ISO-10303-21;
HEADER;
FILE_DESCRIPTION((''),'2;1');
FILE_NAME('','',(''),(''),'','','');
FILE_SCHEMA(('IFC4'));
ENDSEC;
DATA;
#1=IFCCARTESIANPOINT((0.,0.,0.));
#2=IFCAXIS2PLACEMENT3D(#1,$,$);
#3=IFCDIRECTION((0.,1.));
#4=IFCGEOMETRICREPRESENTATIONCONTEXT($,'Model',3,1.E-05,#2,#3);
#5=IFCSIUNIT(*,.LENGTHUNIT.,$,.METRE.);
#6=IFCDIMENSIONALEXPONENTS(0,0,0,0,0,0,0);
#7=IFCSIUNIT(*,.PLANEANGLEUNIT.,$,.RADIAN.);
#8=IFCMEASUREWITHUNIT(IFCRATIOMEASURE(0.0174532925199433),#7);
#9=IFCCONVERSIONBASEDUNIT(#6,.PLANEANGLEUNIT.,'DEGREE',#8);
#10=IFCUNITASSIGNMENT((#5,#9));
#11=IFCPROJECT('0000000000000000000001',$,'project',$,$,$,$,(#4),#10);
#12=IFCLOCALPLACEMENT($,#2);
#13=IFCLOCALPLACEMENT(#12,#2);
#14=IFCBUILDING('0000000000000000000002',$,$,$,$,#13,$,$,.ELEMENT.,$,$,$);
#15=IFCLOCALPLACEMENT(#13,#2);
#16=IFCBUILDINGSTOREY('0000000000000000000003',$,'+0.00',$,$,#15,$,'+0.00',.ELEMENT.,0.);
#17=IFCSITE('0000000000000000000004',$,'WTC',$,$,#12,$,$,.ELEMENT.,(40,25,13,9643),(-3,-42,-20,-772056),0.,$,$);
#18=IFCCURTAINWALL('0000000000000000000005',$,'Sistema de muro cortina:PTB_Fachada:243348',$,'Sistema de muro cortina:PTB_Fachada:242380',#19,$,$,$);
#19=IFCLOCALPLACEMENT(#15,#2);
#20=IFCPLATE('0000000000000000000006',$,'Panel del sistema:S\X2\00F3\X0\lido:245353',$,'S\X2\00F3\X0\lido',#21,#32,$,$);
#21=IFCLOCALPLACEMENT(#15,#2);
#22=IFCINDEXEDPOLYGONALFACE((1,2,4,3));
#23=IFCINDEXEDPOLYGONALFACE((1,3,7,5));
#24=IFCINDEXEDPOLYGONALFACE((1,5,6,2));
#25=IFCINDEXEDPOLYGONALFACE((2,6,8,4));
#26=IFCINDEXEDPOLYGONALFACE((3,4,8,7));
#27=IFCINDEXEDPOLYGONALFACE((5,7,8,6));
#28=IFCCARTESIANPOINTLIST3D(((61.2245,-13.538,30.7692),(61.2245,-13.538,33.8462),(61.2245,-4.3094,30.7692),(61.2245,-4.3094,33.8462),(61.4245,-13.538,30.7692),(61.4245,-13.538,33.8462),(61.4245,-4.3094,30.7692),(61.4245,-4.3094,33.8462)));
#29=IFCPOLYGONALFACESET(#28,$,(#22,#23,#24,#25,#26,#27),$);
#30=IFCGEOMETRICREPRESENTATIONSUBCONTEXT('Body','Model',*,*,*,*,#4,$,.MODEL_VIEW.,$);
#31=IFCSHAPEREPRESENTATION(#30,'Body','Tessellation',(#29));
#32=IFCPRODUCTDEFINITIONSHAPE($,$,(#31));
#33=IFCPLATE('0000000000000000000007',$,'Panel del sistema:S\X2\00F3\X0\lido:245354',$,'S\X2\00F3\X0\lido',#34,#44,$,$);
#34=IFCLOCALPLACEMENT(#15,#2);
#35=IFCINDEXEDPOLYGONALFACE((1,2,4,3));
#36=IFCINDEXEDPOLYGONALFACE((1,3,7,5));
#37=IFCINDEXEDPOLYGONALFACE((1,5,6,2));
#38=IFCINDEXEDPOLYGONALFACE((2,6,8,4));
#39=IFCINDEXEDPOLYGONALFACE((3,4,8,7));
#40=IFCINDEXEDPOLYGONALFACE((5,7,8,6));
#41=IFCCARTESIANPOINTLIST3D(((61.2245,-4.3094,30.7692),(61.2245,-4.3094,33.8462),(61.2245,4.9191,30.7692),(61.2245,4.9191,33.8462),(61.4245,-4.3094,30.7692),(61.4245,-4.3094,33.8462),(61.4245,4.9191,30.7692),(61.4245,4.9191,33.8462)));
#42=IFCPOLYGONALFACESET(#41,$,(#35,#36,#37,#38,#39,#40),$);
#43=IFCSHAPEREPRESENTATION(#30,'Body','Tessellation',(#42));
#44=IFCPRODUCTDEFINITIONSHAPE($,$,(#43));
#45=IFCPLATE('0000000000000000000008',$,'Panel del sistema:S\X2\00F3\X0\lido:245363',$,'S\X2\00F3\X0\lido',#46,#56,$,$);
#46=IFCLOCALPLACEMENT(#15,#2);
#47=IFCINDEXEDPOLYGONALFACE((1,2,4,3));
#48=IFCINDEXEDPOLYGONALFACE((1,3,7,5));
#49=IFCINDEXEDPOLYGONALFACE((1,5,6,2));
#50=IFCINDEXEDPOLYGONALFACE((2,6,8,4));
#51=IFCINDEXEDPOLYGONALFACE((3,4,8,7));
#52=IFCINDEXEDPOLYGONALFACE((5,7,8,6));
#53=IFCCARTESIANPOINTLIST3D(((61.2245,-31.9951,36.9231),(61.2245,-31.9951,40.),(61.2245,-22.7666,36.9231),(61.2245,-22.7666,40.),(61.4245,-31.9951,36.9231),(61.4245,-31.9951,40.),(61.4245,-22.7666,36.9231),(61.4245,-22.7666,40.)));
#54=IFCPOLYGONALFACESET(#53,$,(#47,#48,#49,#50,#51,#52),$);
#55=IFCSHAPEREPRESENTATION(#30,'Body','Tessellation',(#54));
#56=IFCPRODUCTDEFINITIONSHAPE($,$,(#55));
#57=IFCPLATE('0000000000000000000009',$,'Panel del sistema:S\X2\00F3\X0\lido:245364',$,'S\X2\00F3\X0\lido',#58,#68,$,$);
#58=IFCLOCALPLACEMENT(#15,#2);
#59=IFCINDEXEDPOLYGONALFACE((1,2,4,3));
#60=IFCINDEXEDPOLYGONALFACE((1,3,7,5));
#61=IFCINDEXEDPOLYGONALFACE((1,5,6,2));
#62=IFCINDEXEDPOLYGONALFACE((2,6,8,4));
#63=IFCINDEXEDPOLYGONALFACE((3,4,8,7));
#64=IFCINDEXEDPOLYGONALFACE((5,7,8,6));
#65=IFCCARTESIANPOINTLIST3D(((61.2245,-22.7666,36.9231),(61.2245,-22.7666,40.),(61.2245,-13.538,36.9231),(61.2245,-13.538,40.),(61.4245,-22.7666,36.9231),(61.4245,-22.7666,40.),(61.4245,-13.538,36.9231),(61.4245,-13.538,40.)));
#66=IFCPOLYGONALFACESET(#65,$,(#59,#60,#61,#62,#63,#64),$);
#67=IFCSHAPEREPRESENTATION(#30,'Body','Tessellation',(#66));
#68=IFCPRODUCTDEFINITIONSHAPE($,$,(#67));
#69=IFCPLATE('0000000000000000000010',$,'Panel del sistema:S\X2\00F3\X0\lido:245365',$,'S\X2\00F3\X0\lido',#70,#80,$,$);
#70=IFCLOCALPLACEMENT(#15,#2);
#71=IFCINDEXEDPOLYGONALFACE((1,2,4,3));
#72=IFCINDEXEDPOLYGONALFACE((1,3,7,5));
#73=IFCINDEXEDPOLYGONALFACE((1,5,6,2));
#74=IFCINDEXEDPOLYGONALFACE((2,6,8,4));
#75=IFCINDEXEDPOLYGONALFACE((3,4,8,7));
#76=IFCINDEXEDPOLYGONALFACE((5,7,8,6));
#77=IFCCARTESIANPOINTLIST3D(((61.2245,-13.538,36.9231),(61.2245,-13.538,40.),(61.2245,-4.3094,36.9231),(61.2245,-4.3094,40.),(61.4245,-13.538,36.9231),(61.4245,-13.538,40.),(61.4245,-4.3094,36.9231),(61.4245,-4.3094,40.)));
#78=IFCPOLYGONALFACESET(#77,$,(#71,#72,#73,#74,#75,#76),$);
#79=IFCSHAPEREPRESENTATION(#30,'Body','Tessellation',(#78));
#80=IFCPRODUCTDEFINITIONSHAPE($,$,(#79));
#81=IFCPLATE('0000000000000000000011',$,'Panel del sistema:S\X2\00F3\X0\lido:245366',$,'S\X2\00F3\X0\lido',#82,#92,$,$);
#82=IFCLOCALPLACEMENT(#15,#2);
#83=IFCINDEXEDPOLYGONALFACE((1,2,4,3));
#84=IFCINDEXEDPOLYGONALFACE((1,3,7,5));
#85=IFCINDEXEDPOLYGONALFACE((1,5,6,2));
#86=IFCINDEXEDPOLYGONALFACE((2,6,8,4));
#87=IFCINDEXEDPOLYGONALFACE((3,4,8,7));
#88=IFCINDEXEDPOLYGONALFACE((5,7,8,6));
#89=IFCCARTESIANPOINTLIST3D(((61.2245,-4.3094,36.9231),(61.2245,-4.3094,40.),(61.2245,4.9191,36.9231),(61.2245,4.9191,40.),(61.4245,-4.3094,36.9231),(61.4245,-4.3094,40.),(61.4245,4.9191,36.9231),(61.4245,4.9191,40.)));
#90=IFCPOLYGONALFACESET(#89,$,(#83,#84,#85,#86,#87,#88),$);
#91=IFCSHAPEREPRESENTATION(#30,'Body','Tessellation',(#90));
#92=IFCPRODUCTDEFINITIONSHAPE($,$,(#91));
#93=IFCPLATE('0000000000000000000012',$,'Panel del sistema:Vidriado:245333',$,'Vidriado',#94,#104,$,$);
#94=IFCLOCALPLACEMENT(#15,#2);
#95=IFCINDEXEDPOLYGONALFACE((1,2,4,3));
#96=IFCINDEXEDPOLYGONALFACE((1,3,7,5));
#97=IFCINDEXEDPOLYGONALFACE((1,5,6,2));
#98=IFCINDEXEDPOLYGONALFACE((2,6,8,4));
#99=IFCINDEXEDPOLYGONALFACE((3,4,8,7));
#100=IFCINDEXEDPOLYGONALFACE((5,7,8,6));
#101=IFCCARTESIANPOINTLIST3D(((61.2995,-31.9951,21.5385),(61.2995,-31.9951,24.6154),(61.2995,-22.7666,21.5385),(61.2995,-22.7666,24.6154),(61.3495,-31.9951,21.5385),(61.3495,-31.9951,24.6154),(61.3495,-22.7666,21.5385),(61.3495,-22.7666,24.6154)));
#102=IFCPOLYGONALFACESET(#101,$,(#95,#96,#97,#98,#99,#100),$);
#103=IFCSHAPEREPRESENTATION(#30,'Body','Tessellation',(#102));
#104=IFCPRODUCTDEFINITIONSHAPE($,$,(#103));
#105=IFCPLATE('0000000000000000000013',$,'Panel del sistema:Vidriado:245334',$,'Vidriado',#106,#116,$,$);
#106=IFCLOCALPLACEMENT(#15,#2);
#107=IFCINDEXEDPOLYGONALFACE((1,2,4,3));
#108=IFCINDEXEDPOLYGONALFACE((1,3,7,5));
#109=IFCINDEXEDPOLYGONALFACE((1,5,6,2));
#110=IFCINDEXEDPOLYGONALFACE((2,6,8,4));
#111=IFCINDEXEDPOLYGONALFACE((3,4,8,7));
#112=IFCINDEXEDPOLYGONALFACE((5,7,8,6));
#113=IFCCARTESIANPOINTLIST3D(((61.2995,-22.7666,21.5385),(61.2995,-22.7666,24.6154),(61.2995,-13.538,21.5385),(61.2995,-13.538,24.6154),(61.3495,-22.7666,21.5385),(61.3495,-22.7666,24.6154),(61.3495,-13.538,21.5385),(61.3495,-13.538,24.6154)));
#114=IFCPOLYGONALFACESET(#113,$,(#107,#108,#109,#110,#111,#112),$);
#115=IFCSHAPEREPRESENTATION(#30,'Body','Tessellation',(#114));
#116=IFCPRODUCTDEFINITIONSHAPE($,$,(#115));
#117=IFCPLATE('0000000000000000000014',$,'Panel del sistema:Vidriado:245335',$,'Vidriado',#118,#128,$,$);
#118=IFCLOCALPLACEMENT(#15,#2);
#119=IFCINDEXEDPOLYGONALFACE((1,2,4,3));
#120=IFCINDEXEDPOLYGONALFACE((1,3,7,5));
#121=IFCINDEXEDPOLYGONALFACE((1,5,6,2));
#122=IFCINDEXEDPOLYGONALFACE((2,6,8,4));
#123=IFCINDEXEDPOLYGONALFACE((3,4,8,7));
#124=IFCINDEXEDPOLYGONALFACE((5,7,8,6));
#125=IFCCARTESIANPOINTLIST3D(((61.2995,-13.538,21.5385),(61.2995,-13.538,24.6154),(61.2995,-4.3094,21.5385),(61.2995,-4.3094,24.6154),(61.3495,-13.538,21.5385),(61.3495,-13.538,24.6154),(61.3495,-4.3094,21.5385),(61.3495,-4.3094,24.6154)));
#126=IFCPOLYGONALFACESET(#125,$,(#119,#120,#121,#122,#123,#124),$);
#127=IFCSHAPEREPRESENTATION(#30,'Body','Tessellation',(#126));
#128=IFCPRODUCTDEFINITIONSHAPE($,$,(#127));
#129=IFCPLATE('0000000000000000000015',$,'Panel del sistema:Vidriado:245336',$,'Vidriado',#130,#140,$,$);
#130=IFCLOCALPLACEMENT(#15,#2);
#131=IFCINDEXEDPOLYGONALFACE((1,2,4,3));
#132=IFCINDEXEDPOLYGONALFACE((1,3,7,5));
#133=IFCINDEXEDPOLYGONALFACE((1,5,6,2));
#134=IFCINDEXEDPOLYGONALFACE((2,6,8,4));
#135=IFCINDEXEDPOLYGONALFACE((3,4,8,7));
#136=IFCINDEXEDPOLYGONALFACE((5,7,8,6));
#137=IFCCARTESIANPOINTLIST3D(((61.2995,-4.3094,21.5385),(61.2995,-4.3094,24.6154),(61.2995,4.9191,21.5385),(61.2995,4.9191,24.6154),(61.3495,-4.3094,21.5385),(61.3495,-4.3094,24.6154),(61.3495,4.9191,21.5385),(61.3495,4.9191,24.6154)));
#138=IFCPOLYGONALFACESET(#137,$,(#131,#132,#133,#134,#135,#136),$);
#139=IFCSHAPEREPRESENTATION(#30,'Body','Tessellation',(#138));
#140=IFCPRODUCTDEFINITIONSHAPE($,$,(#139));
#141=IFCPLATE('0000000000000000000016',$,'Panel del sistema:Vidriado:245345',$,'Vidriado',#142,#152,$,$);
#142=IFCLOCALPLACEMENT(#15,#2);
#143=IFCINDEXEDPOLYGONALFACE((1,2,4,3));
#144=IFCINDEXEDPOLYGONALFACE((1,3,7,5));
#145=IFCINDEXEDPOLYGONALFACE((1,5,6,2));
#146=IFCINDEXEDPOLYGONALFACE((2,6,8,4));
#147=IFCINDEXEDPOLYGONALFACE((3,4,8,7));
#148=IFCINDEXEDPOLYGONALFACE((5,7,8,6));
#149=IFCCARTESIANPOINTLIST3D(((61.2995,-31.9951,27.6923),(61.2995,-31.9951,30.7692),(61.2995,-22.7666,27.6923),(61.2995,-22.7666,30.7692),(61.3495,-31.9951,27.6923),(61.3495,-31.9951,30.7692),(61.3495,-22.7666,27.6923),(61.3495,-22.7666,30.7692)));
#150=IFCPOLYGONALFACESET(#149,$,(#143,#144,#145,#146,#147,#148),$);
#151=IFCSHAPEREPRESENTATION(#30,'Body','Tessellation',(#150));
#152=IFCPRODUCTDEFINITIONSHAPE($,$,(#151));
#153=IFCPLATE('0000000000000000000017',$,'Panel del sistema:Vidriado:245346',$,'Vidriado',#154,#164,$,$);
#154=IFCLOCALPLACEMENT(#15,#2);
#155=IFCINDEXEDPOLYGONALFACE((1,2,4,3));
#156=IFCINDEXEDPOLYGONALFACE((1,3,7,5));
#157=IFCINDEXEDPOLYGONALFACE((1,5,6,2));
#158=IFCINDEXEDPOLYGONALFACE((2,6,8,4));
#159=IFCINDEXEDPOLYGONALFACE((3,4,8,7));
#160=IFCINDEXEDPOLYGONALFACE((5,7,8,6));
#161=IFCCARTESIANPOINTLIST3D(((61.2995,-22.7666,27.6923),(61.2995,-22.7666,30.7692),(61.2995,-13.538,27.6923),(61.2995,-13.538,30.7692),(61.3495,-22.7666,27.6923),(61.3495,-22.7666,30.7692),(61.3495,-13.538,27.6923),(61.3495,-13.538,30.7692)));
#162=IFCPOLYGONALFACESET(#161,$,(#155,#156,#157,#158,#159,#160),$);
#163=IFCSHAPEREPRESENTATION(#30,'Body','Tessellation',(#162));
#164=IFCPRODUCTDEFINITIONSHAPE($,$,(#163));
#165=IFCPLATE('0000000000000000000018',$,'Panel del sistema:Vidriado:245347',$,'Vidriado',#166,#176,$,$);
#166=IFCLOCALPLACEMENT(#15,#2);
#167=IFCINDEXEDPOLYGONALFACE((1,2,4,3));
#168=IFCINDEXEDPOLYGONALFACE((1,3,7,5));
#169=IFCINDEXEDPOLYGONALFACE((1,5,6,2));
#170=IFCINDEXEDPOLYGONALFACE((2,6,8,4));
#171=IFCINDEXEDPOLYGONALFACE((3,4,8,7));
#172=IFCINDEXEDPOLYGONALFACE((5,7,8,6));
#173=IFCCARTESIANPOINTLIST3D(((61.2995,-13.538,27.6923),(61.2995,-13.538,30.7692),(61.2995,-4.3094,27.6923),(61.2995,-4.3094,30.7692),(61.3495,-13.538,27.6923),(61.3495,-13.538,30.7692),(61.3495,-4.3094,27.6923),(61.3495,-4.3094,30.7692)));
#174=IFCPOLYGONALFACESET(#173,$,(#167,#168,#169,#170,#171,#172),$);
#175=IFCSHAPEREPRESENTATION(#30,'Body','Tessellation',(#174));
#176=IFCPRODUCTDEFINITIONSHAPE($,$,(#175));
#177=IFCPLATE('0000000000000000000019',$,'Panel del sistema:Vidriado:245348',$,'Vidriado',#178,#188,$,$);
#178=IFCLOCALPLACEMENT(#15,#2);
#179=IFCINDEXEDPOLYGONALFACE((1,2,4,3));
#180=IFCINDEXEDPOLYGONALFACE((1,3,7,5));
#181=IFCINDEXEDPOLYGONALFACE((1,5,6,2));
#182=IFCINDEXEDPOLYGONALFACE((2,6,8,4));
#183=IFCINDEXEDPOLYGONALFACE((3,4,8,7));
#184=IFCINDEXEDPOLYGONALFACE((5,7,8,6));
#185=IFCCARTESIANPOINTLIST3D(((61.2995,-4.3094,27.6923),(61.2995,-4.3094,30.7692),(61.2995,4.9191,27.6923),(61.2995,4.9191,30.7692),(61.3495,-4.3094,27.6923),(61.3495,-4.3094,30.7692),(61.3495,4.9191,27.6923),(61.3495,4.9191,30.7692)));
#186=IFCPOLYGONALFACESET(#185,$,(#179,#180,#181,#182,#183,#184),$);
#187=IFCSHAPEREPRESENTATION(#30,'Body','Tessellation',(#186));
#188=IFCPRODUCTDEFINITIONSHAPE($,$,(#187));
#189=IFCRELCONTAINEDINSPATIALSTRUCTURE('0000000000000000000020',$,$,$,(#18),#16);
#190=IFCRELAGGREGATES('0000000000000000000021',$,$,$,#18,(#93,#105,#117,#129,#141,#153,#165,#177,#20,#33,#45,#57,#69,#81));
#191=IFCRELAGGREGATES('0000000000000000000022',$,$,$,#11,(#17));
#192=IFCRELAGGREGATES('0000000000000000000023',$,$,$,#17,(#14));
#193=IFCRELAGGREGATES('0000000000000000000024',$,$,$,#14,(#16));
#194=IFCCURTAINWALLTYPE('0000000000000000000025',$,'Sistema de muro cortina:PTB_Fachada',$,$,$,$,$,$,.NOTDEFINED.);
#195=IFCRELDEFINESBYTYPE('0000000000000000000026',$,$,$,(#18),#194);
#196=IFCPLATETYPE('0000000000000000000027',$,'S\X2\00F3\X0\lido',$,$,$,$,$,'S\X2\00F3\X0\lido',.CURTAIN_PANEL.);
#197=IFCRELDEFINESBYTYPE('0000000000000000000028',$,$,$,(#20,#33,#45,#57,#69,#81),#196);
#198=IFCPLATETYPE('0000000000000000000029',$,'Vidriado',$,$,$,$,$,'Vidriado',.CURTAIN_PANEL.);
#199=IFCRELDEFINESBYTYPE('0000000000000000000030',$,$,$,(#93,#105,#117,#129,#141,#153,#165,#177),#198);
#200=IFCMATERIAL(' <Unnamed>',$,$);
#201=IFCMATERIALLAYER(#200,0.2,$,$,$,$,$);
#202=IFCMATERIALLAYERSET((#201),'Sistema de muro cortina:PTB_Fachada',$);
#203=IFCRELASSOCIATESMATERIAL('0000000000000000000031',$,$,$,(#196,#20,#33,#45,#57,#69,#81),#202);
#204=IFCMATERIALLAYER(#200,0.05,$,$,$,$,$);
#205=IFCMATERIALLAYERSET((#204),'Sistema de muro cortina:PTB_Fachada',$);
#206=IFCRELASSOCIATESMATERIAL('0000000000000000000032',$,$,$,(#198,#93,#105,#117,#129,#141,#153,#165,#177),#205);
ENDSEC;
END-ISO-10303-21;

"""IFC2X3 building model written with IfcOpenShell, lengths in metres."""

from ifc_helpers import new_model, entity, si_unit, converted_unit, direction, frame, frame_2d, origin, origin_2d_with_axis, place, context, subcontext, project, spatial, rectangle, extrude, source, transform, mapped, material, layer, layer_set, layer_usage, type_object, type_shapes, element, aggregate, save


model = new_model("IFC2X3")

# Units and contexts
model_context = context("Model", 3, precision=1e-05, world=origin(), true_north=direction((0.0, 1.0)))
body_context = subcontext(model_context, "Body", "Model", "MODEL_VIEW")
ifc_project = project(units=[si_unit("LENGTHUNIT", "METRE"), converted_unit("PLANEANGLEUNIT", "DEGREE", entity("IfcRatioMeasure", 0.0174532925199433), si_unit("PLANEANGLEUNIT", "RADIAN"), dimensions=[0, 0, 0, 0, 0, 0, 0])], contexts=[model_context])

# Site, building, storey
site_placement = place(None, origin())
site = spatial("IfcSite", under=ifc_project, at=site_placement, Name="WTC", CompositionType="ELEMENT", RefLatitude=(40, 25, 13, 9643), RefLongitude=(-3, -42, -20, -772056), RefElevation=0.0)
building_placement = place(site_placement, origin())
building = spatial("IfcBuilding", under=site, at=building_placement, CompositionType="ELEMENT")
storey_placement = place(building_placement, origin())
storey = spatial("IfcBuildingStorey", under=building, at=storey_placement, Name="+0.00", LongName="+0.00", CompositionType="ELEMENT", Elevation=0.0)

# Curtain wall, plates
curtain_wall_type = type_object("IfcCurtainWallType", Name="Sistema de muro cortina:PTB_Fachada", PredefinedType="NOTDEFINED")
ifc_material_1 = material(Name=" <Unnamed>")
ifc_layer_1 = layer(ifc_material_1, 0.2)
ifc_layer_set_1 = layer_set([ifc_layer_1], Name="Sistema de muro cortina:PTB_Fachada")
ifc_layer_2 = layer(ifc_material_1, 0.05)
ifc_layer_set_2 = layer_set([ifc_layer_2], Name="Sistema de muro cortina:PTB_Fachada")
curtain_wall_1_placement = place(storey_placement, origin())
curtain_wall_1 = element("IfcCurtainWall", 1, at=curtain_wall_1_placement, inside=storey, type_object=curtain_wall_type, Name="Sistema de muro cortina:PTB_Fachada:243348", ObjectType="Sistema de muro cortina:PTB_Fachada:242380")
plate_type_1 = type_object("IfcPlateType", Name="Sólido", ElementType="Sólido", PredefinedType="CURTAIN_PANEL", material=ifc_layer_set_1)
shared_shape_1 = source(origin(), body_context, "Body", "SweptSolid", [
    extrude(rectangle(XDim=0.2, YDim=9.2286, at=frame_2d((0.0, 0.0), x_axis=(1.0, 0.0))), frame((0.0, 0.0, 0.0), z_axis=(0.0, 0.0, 1.0), x_axis=(0.0, 1.0, 0.0)), (0.0, 0.0, 1.0), 3.0769),
])
type_shapes(plate_type_1, [shared_shape_1])
ifc_layer_usage_1 = layer_usage(ifc_layer_set_1, "AXIS3", "POSITIVE", 0.0)
plate_1_placement = place(curtain_wall_1_placement, frame((61.3245, -8.9237, 30.7692), z_axis=(0.0, 0.0, 1.0), x_axis=(0.0, 1.0, 0.0)))
plate_1 = element("IfcPlate", 2, at=plate_1_placement, type_object=plate_type_1, material=ifc_layer_usage_1, Name="Panel del sistema:Sólido:245353", ObjectType="Sólido", context=body_context, shape_type="MappedRepresentation", body=[
    mapped(shared_shape_1, transform((0.0, 0.0, 0.0), scale=1.0)),
])
ifc_layer_usage_2 = layer_usage(ifc_layer_set_1, "AXIS3", "POSITIVE", 0.0)
plate_2_placement = place(curtain_wall_1_placement, frame((61.3245, 0.3049, 30.7692), z_axis=(0.0, 0.0, 1.0), x_axis=(0.0, 1.0, 0.0)))
plate_2 = element("IfcPlate", 3, at=plate_2_placement, type_object=plate_type_1, material=ifc_layer_usage_2, Name="Panel del sistema:Sólido:245354", ObjectType="Sólido", context=body_context, shape_type="MappedRepresentation", body=[
    mapped(shared_shape_1, transform((0.0, 0.0, 0.0), scale=1.0)),
])
ifc_layer_usage_3 = layer_usage(ifc_layer_set_1, "AXIS3", "POSITIVE", 0.0)
plate_3_placement = place(curtain_wall_1_placement, frame((61.3245, -27.3809, 36.9231), z_axis=(0.0, 0.0, 1.0), x_axis=(0.0, 1.0, 0.0)))
plate_3 = element("IfcPlate", 4, at=plate_3_placement, type_object=plate_type_1, material=ifc_layer_usage_3, Name="Panel del sistema:Sólido:245363", ObjectType="Sólido", context=body_context, shape_type="MappedRepresentation", body=[
    mapped(shared_shape_1, transform((0.0, 0.0, 0.0), scale=1.0)),
])
ifc_layer_usage_4 = layer_usage(ifc_layer_set_1, "AXIS3", "POSITIVE", 0.0)
plate_4_placement = place(curtain_wall_1_placement, frame((61.3245, -18.1523, 36.9231), z_axis=(0.0, 0.0, 1.0), x_axis=(0.0, 1.0, 0.0)))
plate_4 = element("IfcPlate", 5, at=plate_4_placement, type_object=plate_type_1, material=ifc_layer_usage_4, Name="Panel del sistema:Sólido:245364", ObjectType="Sólido", context=body_context, shape_type="MappedRepresentation", body=[
    mapped(shared_shape_1, transform((0.0, 0.0, 0.0), scale=1.0)),
])
ifc_layer_usage_5 = layer_usage(ifc_layer_set_1, "AXIS3", "POSITIVE", 0.0)
plate_5_placement = place(curtain_wall_1_placement, frame((61.3245, -8.9237, 36.9231), z_axis=(0.0, 0.0, 1.0), x_axis=(0.0, 1.0, 0.0)))
plate_5 = element("IfcPlate", 6, at=plate_5_placement, type_object=plate_type_1, material=ifc_layer_usage_5, Name="Panel del sistema:Sólido:245365", ObjectType="Sólido", context=body_context, shape_type="MappedRepresentation", body=[
    mapped(shared_shape_1, transform((0.0, 0.0, 0.0), scale=1.0)),
])
ifc_layer_usage_6 = layer_usage(ifc_layer_set_1, "AXIS3", "POSITIVE", 0.0)
plate_6_placement = place(curtain_wall_1_placement, frame((61.3245, 0.3049, 36.9231), z_axis=(0.0, 0.0, 1.0), x_axis=(0.0, 1.0, 0.0)))
plate_6 = element("IfcPlate", 7, at=plate_6_placement, type_object=plate_type_1, material=ifc_layer_usage_6, Name="Panel del sistema:Sólido:245366", ObjectType="Sólido", context=body_context, shape_type="MappedRepresentation", body=[
    mapped(shared_shape_1, transform((0.0, 0.0, 0.0), scale=1.0)),
])
ifc_layer_usage_7 = layer_usage(ifc_layer_set_2, "AXIS3", "POSITIVE", 0.0)
plate_type_2 = type_object("IfcPlateType", Name="Vidriado", ElementType="Vidriado", PredefinedType="CURTAIN_PANEL", material=ifc_layer_set_2)
shared_shape_2 = source(origin(), body_context, "Body", "SweptSolid", [
    extrude(rectangle(XDim=0.05, YDim=9.2286, at=origin_2d_with_axis()), frame((0.0, 0.0, 0.0), z_axis=(0.0, 0.0, 1.0), x_axis=(0.0, 1.0, 0.0)), (0.0, 0.0, 1.0), 3.0769),
])
type_shapes(plate_type_2, [shared_shape_2])
plate_7_placement = place(curtain_wall_1_placement, frame((61.3245, -27.3809, 21.5385), z_axis=(0.0, 0.0, 1.0), x_axis=(0.0, 1.0, 0.0)))
plate_7 = element("IfcPlate", 8, at=plate_7_placement, type_object=plate_type_2, material=ifc_layer_usage_7, Name="Panel del sistema:Vidriado:245333", ObjectType="Vidriado", context=body_context, shape_type="MappedRepresentation", body=[
    mapped(shared_shape_2, transform((0.0, 0.0, 0.0), scale=1.0)),
])
ifc_layer_usage_8 = layer_usage(ifc_layer_set_2, "AXIS3", "POSITIVE", 0.0)
plate_8_placement = place(curtain_wall_1_placement, frame((61.3245, -18.1523, 21.5385), z_axis=(0.0, 0.0, 1.0), x_axis=(0.0, 1.0, 0.0)))
plate_8 = element("IfcPlate", 9, at=plate_8_placement, type_object=plate_type_2, material=ifc_layer_usage_8, Name="Panel del sistema:Vidriado:245334", ObjectType="Vidriado", context=body_context, shape_type="MappedRepresentation", body=[
    mapped(shared_shape_2, transform((0.0, 0.0, 0.0), scale=1.0)),
])
ifc_layer_usage_9 = layer_usage(ifc_layer_set_2, "AXIS3", "POSITIVE", 0.0)
plate_9_placement = place(curtain_wall_1_placement, frame((61.3245, -8.9237, 21.5385), z_axis=(0.0, 0.0, 1.0), x_axis=(0.0, 1.0, 0.0)))
plate_9 = element("IfcPlate", 10, at=plate_9_placement, type_object=plate_type_2, material=ifc_layer_usage_9, Name="Panel del sistema:Vidriado:245335", ObjectType="Vidriado", context=body_context, shape_type="MappedRepresentation", body=[
    mapped(shared_shape_2, transform((0.0, 0.0, 0.0), scale=1.0)),
])
ifc_layer_usage_10 = layer_usage(ifc_layer_set_2, "AXIS3", "POSITIVE", 0.0)
plate_10_placement = place(curtain_wall_1_placement, frame((61.3245, 0.3049, 21.5385), z_axis=(0.0, 0.0, 1.0), x_axis=(0.0, 1.0, 0.0)))
plate_10 = element("IfcPlate", 11, at=plate_10_placement, type_object=plate_type_2, material=ifc_layer_usage_10, Name="Panel del sistema:Vidriado:245336", ObjectType="Vidriado", context=body_context, shape_type="MappedRepresentation", body=[
    mapped(shared_shape_2, transform((0.0, 0.0, 0.0), scale=1.0)),
])
ifc_layer_usage_11 = layer_usage(ifc_layer_set_2, "AXIS3", "POSITIVE", 0.0)
plate_11_placement = place(curtain_wall_1_placement, frame((61.3245, -27.3809, 27.6923), z_axis=(0.0, 0.0, 1.0), x_axis=(0.0, 1.0, 0.0)))
plate_11 = element("IfcPlate", 12, at=plate_11_placement, type_object=plate_type_2, material=ifc_layer_usage_11, Name="Panel del sistema:Vidriado:245345", ObjectType="Vidriado", context=body_context, shape_type="MappedRepresentation", body=[
    mapped(shared_shape_2, transform((0.0, 0.0, 0.0), scale=1.0)),
])
ifc_layer_usage_12 = layer_usage(ifc_layer_set_2, "AXIS3", "POSITIVE", 0.0)
plate_12_placement = place(curtain_wall_1_placement, frame((61.3245, -18.1523, 27.6923), z_axis=(0.0, 0.0, 1.0), x_axis=(0.0, 1.0, 0.0)))
plate_12 = element("IfcPlate", 13, at=plate_12_placement, type_object=plate_type_2, material=ifc_layer_usage_12, Name="Panel del sistema:Vidriado:245346", ObjectType="Vidriado", context=body_context, shape_type="MappedRepresentation", body=[
    mapped(shared_shape_2, transform((0.0, 0.0, 0.0), scale=1.0)),
])
ifc_layer_usage_13 = layer_usage(ifc_layer_set_2, "AXIS3", "POSITIVE", 0.0)
plate_13_placement = place(curtain_wall_1_placement, frame((61.3245, -8.9237, 27.6923), z_axis=(0.0, 0.0, 1.0), x_axis=(0.0, 1.0, 0.0)))
plate_13 = element("IfcPlate", 14, at=plate_13_placement, type_object=plate_type_2, material=ifc_layer_usage_13, Name="Panel del sistema:Vidriado:245347", ObjectType="Vidriado", context=body_context, shape_type="MappedRepresentation", body=[
    mapped(shared_shape_2, transform((0.0, 0.0, 0.0), scale=1.0)),
])
ifc_layer_usage_14 = layer_usage(ifc_layer_set_2, "AXIS3", "POSITIVE", 0.0)
plate_14_placement = place(curtain_wall_1_placement, frame((61.3245, 0.3049, 27.6923), z_axis=(0.0, 0.0, 1.0), x_axis=(0.0, 1.0, 0.0)))
plate_14 = element("IfcPlate", 15, at=plate_14_placement, type_object=plate_type_2, material=ifc_layer_usage_14, Name="Panel del sistema:Vidriado:245348", ObjectType="Vidriado", context=body_context, shape_type="MappedRepresentation", body=[
    mapped(shared_shape_2, transform((0.0, 0.0, 0.0), scale=1.0)),
])
aggregate(curtain_wall_1, [plate_7, plate_8, plate_9, plate_10, plate_11, plate_12, plate_13, plate_14, plate_1, plate_2, plate_3, plate_4, plate_5, plate_6])

save(model, "model.ifc")
